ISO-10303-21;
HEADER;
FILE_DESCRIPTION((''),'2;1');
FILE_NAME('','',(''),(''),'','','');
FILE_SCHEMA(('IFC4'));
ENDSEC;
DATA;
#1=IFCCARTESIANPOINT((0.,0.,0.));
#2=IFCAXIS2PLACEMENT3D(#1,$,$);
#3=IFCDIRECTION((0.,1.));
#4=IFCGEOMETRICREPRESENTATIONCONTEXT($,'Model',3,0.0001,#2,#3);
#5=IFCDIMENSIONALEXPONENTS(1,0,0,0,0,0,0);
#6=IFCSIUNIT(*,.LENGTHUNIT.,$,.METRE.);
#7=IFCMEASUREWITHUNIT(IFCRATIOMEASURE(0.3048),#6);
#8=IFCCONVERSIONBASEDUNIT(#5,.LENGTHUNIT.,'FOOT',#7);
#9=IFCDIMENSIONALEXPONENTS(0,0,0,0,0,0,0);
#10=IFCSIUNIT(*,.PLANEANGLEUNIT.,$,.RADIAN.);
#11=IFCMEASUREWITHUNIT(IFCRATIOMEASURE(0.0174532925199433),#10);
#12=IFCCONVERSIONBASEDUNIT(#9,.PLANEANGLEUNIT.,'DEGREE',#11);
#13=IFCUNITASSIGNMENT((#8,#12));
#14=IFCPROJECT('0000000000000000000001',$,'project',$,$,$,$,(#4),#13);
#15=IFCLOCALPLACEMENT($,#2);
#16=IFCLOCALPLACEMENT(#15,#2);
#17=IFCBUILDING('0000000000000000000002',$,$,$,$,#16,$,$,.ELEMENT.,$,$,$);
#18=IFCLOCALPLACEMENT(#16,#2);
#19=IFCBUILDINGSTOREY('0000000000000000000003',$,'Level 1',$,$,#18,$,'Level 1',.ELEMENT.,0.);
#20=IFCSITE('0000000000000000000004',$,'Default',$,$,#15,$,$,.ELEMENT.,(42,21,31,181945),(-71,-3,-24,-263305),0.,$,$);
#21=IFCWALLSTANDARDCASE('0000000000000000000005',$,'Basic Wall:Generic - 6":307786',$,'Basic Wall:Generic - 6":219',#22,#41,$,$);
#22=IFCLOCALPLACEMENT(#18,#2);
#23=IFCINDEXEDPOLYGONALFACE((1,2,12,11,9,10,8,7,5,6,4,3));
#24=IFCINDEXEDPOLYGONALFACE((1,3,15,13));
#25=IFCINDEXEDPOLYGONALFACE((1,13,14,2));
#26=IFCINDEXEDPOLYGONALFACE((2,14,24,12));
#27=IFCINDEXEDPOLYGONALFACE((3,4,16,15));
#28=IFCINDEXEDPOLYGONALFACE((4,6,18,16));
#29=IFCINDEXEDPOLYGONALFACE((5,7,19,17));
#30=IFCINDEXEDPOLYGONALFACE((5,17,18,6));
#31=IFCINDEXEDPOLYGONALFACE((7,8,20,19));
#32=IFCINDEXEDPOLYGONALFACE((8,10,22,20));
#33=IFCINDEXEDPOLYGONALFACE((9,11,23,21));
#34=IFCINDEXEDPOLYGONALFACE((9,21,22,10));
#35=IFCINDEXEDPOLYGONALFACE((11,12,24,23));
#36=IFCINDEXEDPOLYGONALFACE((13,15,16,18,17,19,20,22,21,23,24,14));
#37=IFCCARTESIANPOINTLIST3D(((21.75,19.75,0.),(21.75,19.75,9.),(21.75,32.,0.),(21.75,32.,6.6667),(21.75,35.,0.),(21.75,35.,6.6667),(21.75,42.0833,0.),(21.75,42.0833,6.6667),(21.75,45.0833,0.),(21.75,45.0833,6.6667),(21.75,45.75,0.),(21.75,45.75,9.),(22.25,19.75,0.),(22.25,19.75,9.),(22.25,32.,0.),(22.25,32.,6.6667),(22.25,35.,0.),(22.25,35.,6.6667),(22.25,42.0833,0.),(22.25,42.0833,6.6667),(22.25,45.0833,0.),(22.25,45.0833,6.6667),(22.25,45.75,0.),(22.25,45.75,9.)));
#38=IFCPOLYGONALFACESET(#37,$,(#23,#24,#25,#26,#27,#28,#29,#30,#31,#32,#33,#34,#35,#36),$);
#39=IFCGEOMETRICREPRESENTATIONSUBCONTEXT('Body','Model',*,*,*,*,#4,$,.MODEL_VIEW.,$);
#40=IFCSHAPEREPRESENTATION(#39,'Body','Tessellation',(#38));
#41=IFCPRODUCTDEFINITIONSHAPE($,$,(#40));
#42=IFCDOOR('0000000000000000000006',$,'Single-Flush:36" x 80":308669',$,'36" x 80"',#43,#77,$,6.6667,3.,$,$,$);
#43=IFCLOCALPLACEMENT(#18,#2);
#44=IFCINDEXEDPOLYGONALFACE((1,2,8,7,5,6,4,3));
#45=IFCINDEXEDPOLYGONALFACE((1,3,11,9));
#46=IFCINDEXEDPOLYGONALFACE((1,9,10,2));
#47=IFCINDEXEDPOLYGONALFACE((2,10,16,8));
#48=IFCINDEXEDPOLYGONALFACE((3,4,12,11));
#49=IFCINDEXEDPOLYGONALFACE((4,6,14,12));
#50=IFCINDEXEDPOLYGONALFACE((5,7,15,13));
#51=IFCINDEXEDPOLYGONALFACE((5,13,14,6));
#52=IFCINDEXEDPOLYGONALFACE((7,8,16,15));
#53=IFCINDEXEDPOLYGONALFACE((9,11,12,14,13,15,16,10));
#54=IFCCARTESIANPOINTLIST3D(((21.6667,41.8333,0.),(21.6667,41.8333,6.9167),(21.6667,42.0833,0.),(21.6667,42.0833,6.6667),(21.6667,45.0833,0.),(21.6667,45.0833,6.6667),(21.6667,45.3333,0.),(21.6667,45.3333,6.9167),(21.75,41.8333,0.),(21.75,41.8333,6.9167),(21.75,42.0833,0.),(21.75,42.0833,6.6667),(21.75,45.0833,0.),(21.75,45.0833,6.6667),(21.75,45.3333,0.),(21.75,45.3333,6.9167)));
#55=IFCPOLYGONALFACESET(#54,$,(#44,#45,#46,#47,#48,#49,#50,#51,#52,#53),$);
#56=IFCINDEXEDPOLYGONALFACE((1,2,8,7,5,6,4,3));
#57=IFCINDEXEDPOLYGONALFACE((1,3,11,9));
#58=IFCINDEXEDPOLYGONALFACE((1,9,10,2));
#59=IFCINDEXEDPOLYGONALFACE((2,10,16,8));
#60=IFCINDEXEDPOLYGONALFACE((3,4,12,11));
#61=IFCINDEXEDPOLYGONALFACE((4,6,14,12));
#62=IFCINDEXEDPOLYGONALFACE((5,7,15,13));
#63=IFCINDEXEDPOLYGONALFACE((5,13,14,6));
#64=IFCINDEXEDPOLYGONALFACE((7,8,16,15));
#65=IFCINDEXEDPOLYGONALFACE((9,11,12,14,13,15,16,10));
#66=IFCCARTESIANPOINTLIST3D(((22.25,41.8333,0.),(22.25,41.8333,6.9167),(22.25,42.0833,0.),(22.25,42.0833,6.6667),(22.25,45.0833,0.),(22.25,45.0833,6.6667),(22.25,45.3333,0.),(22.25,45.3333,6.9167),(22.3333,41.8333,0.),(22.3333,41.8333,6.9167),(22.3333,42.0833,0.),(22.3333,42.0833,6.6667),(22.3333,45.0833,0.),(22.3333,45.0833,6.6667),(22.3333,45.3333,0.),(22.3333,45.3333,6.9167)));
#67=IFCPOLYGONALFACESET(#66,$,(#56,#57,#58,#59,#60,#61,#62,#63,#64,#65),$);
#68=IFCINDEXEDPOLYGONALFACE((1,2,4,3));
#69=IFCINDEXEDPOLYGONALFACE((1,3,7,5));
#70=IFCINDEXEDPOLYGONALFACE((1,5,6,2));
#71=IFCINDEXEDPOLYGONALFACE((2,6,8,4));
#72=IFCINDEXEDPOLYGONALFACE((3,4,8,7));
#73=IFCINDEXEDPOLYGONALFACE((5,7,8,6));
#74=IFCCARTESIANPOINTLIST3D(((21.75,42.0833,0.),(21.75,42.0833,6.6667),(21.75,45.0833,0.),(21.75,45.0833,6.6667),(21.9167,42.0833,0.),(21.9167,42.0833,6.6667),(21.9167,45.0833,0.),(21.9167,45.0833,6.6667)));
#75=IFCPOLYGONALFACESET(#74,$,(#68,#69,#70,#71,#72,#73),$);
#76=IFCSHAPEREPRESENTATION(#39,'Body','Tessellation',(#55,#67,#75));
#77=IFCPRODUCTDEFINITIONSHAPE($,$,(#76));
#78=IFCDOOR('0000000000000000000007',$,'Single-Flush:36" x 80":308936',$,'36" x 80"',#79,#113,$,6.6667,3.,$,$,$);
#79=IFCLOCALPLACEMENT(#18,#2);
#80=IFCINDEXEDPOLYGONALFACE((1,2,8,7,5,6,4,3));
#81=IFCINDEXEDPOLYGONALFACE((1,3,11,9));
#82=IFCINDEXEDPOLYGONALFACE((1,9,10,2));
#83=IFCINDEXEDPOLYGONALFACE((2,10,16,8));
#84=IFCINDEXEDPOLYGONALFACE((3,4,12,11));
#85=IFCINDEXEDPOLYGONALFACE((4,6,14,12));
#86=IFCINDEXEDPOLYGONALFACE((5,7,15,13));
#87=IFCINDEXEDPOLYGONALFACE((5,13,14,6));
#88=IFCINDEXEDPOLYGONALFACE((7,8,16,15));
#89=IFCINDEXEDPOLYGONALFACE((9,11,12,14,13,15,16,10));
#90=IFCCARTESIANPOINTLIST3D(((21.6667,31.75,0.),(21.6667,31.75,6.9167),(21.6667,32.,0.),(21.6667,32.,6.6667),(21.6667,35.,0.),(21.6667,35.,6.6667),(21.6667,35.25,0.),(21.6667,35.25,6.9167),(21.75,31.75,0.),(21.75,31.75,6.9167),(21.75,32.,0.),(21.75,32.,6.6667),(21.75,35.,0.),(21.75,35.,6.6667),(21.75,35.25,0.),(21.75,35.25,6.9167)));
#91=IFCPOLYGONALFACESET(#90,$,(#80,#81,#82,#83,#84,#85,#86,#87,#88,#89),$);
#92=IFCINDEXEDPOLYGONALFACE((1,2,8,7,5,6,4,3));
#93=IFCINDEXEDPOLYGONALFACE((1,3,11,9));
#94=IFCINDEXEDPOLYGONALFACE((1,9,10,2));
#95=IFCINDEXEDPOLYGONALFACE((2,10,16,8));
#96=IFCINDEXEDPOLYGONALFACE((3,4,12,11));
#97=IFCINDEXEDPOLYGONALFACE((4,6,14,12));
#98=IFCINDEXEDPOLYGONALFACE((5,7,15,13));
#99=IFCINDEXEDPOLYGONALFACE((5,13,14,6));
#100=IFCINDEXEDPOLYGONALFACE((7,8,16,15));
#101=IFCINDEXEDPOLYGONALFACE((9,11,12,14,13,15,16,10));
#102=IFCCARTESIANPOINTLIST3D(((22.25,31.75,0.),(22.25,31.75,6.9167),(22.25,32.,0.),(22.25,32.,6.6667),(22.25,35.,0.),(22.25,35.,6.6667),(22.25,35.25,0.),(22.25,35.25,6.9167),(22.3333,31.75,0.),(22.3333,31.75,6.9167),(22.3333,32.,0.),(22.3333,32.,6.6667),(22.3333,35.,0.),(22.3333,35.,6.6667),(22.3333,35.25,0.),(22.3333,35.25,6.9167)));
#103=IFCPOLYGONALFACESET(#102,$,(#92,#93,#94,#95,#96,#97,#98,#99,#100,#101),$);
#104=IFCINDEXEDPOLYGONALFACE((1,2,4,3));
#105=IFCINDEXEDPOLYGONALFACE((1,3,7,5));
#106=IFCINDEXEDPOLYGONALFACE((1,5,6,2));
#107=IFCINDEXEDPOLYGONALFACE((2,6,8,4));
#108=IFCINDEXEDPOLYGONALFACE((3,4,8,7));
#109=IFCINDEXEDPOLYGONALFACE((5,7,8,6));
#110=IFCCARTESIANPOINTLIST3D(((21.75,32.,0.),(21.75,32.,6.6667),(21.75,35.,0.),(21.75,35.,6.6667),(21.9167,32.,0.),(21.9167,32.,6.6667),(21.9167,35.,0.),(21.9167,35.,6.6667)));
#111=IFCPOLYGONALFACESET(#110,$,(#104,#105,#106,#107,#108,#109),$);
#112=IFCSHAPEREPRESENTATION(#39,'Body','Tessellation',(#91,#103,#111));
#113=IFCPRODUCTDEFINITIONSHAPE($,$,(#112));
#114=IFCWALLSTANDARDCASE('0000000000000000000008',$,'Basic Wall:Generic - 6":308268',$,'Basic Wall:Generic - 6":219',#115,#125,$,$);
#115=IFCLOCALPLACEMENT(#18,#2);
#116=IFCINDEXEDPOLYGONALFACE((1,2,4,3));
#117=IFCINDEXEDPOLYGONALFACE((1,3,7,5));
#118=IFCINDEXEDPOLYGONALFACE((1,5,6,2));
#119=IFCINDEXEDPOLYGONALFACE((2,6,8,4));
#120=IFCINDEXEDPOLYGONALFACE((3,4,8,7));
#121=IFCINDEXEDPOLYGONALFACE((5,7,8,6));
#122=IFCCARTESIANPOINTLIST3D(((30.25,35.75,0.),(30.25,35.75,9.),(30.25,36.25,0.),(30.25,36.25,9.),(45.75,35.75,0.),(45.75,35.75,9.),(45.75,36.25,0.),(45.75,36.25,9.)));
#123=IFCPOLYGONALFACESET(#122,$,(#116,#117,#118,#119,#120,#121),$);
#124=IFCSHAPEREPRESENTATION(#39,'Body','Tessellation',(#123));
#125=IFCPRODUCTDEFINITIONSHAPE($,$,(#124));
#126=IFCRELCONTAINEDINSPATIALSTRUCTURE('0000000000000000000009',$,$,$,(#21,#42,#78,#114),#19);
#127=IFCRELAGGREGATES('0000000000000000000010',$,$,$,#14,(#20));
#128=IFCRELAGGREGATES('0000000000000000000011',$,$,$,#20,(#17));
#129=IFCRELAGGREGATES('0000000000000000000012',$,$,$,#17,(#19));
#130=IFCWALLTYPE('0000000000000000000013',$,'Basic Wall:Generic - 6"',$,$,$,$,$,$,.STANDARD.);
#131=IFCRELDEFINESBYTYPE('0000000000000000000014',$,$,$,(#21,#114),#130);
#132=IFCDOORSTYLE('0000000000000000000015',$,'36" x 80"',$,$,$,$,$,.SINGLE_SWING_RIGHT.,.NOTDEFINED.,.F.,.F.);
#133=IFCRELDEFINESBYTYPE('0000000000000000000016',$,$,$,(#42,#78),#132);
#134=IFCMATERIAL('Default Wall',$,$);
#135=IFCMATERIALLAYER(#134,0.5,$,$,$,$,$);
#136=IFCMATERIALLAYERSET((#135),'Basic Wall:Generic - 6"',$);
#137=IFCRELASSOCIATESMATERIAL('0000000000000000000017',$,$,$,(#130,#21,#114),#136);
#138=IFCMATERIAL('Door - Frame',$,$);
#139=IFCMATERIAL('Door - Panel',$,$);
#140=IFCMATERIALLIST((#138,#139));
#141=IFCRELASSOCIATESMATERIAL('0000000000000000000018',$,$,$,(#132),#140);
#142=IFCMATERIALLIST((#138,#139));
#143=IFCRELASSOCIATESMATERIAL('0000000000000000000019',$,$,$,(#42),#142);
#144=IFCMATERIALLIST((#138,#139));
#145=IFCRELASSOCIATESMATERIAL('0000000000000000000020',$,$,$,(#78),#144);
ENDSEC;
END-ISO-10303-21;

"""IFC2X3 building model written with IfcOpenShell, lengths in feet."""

from ifc_helpers import new_model, entity, si_unit, converted_unit, direction, frame, frame_2d, origin, origin_2d_with_axis, place, context, subcontext, project, spatial, polyline, rectangle, outline, extrude, clip, bounded_halfspace, source, transform, mapped, material, material_list, layer, layer_set, layer_usage, type_object, type_shapes, element, fill, save


model = new_model("IFC2X3")

# Units and contexts
model_context = context("Model", 3, precision=0.0001, world=origin(), true_north=direction((0.0, 1.0)))
body_context = subcontext(model_context, "Body", "Model", "MODEL_VIEW")
ifc_project = project(units=[converted_unit("LENGTHUNIT", "FOOT", entity("IfcRatioMeasure", 0.3048), si_unit("LENGTHUNIT", "METRE"), dimensions=[1, 0, 0, 0, 0, 0, 0]), converted_unit("PLANEANGLEUNIT", "DEGREE", entity("IfcRatioMeasure", 0.0174532925199433), si_unit("PLANEANGLEUNIT", "RADIAN"), dimensions=[0, 0, 0, 0, 0, 0, 0])], contexts=[model_context])

# Site, building, storey
site_placement = place(None, origin())
site = spatial("IfcSite", under=ifc_project, at=site_placement, Name="Default", CompositionType="ELEMENT", RefLatitude=(42, 21, 31, 181945), RefLongitude=(-71, -3, -24, -263305), RefElevation=0.0)
building_placement = place(site_placement, origin())
building = spatial("IfcBuilding", under=site, at=building_placement, CompositionType="ELEMENT")
storey_placement = place(building_placement, origin())
storey = spatial("IfcBuildingStorey", under=building, at=storey_placement, Name="Level 1", LongName="Level 1", CompositionType="ELEMENT", Elevation=0.0)

# Shared definitions
ifc_material_1 = material(Name="Default Wall")
ifc_layer = layer(ifc_material_1, 0.5)
ifc_layer_set = layer_set([ifc_layer], Name="Basic Wall:Generic - 6\"")
wall_type = type_object("IfcWallType", Name="Basic Wall:Generic - 6\"", PredefinedType="STANDARD", material=ifc_layer_set)
ifc_material_2 = material(Name="Door - Frame")
ifc_material_3 = material(Name="Door - Panel")
ifc_material_list_1 = material_list([ifc_material_2, ifc_material_3])
door_style_1 = type_object("IfcDoorStyle", Name="36\" x 80\"", ConstructionType="NOTDEFINED", OperationType="SINGLE_SWING_RIGHT", ParameterTakesPrecedence=False, Sizeable=False, material=ifc_material_list_1)
shared_shape_1 = source(origin(), body_context, "Body", "SweptSolid", [
    extrude(outline(polyline([(-1.75, -3.5208), (1.75, -3.5208), (1.75, 3.3958), (1.5, 3.3958), (1.5, -3.2708), (-1.5, -3.2708), (-1.5, 3.3958), (-1.75, 3.3958), (-1.75, -3.5208)])), frame((1.5, 0.5, 3.3958), z_axis=(0.0, 1.0, 0.0), x_axis=(1.0, 0.0, 0.0)), (0.0, 0.0, 1.0), 0.0833),
    extrude(outline(polyline([(-3.5208, -1.75), (3.3958, -1.75), (3.3958, -1.5), (-3.2708, -1.5), (-3.2708, 1.5), (3.3958, 1.5), (3.3958, 1.75), (-3.5208, 1.75), (-3.5208, -1.75)])), frame((1.5, -0.0833, 3.3958), z_axis=(0.0, 1.0, 0.0), x_axis=(0.0, 0.0, -1.0)), (0.0, 0.0, 1.0), 0.0833),
    extrude(rectangle(XDim=0.1667, YDim=3.0, at=origin_2d_with_axis()), frame((1.5, 0.4167, 0.0), z_axis=(0.0, 0.0, 1.0), x_axis=(0.0, 1.0, 0.0)), (0.0, 0.0, 1.0), 6.6667),
])
type_shapes(door_style_1, [shared_shape_1])

# Wall, openings, doors
ifc_layer_usage_1 = layer_usage(ifc_layer_set, "AXIS2", "NEGATIVE", 0.25)
wall_1_placement = place(storey_placement, frame((22.0, 45.75, 0.0), z_axis=(0.0, 0.0, 1.0), x_axis=(0.0, -1.0, 0.0)))
wall_1 = element("IfcWallStandardCase", 1, at=wall_1_placement, inside=storey, type_object=wall_type, material=ifc_layer_usage_1, Name="Basic Wall:Generic - 6\":307786", ObjectType="Basic Wall:Generic - 6\":219", context=body_context, shape_type="Clipping", body=[
    clip(clip(clip(extrude(rectangle(XDim=26.0, YDim=0.5, at=frame_2d((13.0, 0.0), x_axis=(-1.0, 0.0))), origin(), (0.0, 0.0, 1.0), 9.0), bounded_halfspace(frame((10.0, -0.25, 9.0), z_axis=(0.0, 0.0, -1.0), x_axis=(0.0, -1.0, 0.0)), True, frame((10.0, -0.25, 9.0)), polyline([(0.0, 0.0), (0.0, 0.5), (-10.0, 0.5), (-10.0, 0.0), (-0.5, 0.0), (0.0, 0.0)]))), bounded_halfspace(frame((10.0, -0.25, 9.0), z_axis=(0.0, 0.0, -1.0), x_axis=(-1.0, 0.0, 0.0)), True, frame((10.0, -0.25, 9.0)), polyline([(0.0, 0.0), (15.5, 0.0), (15.5, 0.5), (0.0, 0.5), (0.0, 0.0)]))), bounded_halfspace(frame((25.5, -0.25, 9.0), z_axis=(0.0, 0.0, -1.0), x_axis=(1.0, 0.0, 0.0)), True, frame((25.5, -0.25, 9.0)), polyline([(0.0, 0.0), (0.5, 0.0), (0.5, 0.5), (0.0, 0.5), (0.0, 0.0)]))),
])
opening_1_placement = place(wall_1_placement, frame((3.6667, 0.25, 0.0)))
opening_1 = element("IfcOpeningElement", 2, at=opening_1_placement, cuts=wall_1, ObjectType="Opening", context=body_context, shape_type="SweptSolid", body=[
    extrude(rectangle(XDim=3.0, YDim=6.6667, at=frame_2d((3.3333, 1.5), x_axis=(0.0, 1.0))), frame((0.0, 0.0, 0.0), z_axis=(0.0, -1.0, 0.0), x_axis=(0.0, 0.0, 1.0)), (0.0, 0.0, 1.0), 0.5),
])
opening_2_placement = place(wall_1_placement, frame((13.75, 0.25, 0.0)))
opening_2 = element("IfcOpeningElement", 3, at=opening_2_placement, cuts=wall_1, ObjectType="Opening", context=body_context, shape_type="SweptSolid", body=[
    extrude(rectangle(XDim=3.0, YDim=6.6667, at=frame_2d((3.3333, 1.5), x_axis=(0.0, 1.0))), frame((0.0, 0.0, 0.0), z_axis=(0.0, -1.0, 0.0), x_axis=(0.0, 0.0, 1.0)), (0.0, 0.0, 1.0), 0.5),
])
ifc_material_list_2 = material_list([ifc_material_2, ifc_material_3])
door_1_placement = place(opening_1_placement, frame((0.0, 0.0, 0.0), z_axis=(0.0, 0.0, 1.0), x_axis=(-1.0, 0.0, 0.0)))
door_1 = element("IfcDoor", 4, at=door_1_placement, inside=storey, type_object=door_style_1, material=ifc_material_list_2, Name="Single-Flush:36\" x 80\":308669", ObjectType="36\" x 80\"", OverallHeight=6.6667, OverallWidth=3.0, context=body_context, shape_type="MappedRepresentation", body=[
    mapped(shared_shape_1, transform((0.0, 0.0, 0.0), scale=1.0)),
])
fill(opening_1, door_1)
ifc_material_list_3 = material_list([ifc_material_2, ifc_material_3])
door_2_placement = place(opening_2_placement, frame((0.0, 0.0, 0.0), z_axis=(0.0, 0.0, 1.0), x_axis=(-1.0, 0.0, 0.0)))
door_2 = element("IfcDoor", 5, at=door_2_placement, inside=storey, type_object=door_style_1, material=ifc_material_list_3, Name="Single-Flush:36\" x 80\":308936", ObjectType="36\" x 80\"", OverallHeight=6.6667, OverallWidth=3.0, context=body_context, shape_type="MappedRepresentation", body=[
    mapped(shared_shape_1, transform((0.0, 0.0, 0.0), scale=1.0)),
])
fill(opening_2, door_2)

# Wall
ifc_layer_usage_2 = layer_usage(ifc_layer_set, "AXIS2", "NEGATIVE", 0.25)
wall_2_placement = place(storey_placement, frame((30.25, 36.0, 0.0)))
element("IfcWallStandardCase", 6, at=wall_2_placement, inside=storey, type_object=wall_type, material=ifc_layer_usage_2, Name="Basic Wall:Generic - 6\":308268", ObjectType="Basic Wall:Generic - 6\":219", context=body_context, shape_type="Clipping", body=[
    clip(extrude(rectangle(XDim=15.5, YDim=0.5, at=frame_2d((7.75, 0.0), x_axis=(-1.0, 0.0))), origin(), (0.0, 0.0, 1.0), 9.0), bounded_halfspace(frame((0.0, -0.25, 9.0), z_axis=(0.0, 0.0, -1.0), x_axis=(1.0, 0.0, 0.0)), True, frame((0.0, -0.25, 9.0)), polyline([(0.0, 0.0), (15.5, 0.0), (15.5, 0.5), (0.0, 0.5), (0.0, 0.0)]))),
])

save(model, "model.ifc")
